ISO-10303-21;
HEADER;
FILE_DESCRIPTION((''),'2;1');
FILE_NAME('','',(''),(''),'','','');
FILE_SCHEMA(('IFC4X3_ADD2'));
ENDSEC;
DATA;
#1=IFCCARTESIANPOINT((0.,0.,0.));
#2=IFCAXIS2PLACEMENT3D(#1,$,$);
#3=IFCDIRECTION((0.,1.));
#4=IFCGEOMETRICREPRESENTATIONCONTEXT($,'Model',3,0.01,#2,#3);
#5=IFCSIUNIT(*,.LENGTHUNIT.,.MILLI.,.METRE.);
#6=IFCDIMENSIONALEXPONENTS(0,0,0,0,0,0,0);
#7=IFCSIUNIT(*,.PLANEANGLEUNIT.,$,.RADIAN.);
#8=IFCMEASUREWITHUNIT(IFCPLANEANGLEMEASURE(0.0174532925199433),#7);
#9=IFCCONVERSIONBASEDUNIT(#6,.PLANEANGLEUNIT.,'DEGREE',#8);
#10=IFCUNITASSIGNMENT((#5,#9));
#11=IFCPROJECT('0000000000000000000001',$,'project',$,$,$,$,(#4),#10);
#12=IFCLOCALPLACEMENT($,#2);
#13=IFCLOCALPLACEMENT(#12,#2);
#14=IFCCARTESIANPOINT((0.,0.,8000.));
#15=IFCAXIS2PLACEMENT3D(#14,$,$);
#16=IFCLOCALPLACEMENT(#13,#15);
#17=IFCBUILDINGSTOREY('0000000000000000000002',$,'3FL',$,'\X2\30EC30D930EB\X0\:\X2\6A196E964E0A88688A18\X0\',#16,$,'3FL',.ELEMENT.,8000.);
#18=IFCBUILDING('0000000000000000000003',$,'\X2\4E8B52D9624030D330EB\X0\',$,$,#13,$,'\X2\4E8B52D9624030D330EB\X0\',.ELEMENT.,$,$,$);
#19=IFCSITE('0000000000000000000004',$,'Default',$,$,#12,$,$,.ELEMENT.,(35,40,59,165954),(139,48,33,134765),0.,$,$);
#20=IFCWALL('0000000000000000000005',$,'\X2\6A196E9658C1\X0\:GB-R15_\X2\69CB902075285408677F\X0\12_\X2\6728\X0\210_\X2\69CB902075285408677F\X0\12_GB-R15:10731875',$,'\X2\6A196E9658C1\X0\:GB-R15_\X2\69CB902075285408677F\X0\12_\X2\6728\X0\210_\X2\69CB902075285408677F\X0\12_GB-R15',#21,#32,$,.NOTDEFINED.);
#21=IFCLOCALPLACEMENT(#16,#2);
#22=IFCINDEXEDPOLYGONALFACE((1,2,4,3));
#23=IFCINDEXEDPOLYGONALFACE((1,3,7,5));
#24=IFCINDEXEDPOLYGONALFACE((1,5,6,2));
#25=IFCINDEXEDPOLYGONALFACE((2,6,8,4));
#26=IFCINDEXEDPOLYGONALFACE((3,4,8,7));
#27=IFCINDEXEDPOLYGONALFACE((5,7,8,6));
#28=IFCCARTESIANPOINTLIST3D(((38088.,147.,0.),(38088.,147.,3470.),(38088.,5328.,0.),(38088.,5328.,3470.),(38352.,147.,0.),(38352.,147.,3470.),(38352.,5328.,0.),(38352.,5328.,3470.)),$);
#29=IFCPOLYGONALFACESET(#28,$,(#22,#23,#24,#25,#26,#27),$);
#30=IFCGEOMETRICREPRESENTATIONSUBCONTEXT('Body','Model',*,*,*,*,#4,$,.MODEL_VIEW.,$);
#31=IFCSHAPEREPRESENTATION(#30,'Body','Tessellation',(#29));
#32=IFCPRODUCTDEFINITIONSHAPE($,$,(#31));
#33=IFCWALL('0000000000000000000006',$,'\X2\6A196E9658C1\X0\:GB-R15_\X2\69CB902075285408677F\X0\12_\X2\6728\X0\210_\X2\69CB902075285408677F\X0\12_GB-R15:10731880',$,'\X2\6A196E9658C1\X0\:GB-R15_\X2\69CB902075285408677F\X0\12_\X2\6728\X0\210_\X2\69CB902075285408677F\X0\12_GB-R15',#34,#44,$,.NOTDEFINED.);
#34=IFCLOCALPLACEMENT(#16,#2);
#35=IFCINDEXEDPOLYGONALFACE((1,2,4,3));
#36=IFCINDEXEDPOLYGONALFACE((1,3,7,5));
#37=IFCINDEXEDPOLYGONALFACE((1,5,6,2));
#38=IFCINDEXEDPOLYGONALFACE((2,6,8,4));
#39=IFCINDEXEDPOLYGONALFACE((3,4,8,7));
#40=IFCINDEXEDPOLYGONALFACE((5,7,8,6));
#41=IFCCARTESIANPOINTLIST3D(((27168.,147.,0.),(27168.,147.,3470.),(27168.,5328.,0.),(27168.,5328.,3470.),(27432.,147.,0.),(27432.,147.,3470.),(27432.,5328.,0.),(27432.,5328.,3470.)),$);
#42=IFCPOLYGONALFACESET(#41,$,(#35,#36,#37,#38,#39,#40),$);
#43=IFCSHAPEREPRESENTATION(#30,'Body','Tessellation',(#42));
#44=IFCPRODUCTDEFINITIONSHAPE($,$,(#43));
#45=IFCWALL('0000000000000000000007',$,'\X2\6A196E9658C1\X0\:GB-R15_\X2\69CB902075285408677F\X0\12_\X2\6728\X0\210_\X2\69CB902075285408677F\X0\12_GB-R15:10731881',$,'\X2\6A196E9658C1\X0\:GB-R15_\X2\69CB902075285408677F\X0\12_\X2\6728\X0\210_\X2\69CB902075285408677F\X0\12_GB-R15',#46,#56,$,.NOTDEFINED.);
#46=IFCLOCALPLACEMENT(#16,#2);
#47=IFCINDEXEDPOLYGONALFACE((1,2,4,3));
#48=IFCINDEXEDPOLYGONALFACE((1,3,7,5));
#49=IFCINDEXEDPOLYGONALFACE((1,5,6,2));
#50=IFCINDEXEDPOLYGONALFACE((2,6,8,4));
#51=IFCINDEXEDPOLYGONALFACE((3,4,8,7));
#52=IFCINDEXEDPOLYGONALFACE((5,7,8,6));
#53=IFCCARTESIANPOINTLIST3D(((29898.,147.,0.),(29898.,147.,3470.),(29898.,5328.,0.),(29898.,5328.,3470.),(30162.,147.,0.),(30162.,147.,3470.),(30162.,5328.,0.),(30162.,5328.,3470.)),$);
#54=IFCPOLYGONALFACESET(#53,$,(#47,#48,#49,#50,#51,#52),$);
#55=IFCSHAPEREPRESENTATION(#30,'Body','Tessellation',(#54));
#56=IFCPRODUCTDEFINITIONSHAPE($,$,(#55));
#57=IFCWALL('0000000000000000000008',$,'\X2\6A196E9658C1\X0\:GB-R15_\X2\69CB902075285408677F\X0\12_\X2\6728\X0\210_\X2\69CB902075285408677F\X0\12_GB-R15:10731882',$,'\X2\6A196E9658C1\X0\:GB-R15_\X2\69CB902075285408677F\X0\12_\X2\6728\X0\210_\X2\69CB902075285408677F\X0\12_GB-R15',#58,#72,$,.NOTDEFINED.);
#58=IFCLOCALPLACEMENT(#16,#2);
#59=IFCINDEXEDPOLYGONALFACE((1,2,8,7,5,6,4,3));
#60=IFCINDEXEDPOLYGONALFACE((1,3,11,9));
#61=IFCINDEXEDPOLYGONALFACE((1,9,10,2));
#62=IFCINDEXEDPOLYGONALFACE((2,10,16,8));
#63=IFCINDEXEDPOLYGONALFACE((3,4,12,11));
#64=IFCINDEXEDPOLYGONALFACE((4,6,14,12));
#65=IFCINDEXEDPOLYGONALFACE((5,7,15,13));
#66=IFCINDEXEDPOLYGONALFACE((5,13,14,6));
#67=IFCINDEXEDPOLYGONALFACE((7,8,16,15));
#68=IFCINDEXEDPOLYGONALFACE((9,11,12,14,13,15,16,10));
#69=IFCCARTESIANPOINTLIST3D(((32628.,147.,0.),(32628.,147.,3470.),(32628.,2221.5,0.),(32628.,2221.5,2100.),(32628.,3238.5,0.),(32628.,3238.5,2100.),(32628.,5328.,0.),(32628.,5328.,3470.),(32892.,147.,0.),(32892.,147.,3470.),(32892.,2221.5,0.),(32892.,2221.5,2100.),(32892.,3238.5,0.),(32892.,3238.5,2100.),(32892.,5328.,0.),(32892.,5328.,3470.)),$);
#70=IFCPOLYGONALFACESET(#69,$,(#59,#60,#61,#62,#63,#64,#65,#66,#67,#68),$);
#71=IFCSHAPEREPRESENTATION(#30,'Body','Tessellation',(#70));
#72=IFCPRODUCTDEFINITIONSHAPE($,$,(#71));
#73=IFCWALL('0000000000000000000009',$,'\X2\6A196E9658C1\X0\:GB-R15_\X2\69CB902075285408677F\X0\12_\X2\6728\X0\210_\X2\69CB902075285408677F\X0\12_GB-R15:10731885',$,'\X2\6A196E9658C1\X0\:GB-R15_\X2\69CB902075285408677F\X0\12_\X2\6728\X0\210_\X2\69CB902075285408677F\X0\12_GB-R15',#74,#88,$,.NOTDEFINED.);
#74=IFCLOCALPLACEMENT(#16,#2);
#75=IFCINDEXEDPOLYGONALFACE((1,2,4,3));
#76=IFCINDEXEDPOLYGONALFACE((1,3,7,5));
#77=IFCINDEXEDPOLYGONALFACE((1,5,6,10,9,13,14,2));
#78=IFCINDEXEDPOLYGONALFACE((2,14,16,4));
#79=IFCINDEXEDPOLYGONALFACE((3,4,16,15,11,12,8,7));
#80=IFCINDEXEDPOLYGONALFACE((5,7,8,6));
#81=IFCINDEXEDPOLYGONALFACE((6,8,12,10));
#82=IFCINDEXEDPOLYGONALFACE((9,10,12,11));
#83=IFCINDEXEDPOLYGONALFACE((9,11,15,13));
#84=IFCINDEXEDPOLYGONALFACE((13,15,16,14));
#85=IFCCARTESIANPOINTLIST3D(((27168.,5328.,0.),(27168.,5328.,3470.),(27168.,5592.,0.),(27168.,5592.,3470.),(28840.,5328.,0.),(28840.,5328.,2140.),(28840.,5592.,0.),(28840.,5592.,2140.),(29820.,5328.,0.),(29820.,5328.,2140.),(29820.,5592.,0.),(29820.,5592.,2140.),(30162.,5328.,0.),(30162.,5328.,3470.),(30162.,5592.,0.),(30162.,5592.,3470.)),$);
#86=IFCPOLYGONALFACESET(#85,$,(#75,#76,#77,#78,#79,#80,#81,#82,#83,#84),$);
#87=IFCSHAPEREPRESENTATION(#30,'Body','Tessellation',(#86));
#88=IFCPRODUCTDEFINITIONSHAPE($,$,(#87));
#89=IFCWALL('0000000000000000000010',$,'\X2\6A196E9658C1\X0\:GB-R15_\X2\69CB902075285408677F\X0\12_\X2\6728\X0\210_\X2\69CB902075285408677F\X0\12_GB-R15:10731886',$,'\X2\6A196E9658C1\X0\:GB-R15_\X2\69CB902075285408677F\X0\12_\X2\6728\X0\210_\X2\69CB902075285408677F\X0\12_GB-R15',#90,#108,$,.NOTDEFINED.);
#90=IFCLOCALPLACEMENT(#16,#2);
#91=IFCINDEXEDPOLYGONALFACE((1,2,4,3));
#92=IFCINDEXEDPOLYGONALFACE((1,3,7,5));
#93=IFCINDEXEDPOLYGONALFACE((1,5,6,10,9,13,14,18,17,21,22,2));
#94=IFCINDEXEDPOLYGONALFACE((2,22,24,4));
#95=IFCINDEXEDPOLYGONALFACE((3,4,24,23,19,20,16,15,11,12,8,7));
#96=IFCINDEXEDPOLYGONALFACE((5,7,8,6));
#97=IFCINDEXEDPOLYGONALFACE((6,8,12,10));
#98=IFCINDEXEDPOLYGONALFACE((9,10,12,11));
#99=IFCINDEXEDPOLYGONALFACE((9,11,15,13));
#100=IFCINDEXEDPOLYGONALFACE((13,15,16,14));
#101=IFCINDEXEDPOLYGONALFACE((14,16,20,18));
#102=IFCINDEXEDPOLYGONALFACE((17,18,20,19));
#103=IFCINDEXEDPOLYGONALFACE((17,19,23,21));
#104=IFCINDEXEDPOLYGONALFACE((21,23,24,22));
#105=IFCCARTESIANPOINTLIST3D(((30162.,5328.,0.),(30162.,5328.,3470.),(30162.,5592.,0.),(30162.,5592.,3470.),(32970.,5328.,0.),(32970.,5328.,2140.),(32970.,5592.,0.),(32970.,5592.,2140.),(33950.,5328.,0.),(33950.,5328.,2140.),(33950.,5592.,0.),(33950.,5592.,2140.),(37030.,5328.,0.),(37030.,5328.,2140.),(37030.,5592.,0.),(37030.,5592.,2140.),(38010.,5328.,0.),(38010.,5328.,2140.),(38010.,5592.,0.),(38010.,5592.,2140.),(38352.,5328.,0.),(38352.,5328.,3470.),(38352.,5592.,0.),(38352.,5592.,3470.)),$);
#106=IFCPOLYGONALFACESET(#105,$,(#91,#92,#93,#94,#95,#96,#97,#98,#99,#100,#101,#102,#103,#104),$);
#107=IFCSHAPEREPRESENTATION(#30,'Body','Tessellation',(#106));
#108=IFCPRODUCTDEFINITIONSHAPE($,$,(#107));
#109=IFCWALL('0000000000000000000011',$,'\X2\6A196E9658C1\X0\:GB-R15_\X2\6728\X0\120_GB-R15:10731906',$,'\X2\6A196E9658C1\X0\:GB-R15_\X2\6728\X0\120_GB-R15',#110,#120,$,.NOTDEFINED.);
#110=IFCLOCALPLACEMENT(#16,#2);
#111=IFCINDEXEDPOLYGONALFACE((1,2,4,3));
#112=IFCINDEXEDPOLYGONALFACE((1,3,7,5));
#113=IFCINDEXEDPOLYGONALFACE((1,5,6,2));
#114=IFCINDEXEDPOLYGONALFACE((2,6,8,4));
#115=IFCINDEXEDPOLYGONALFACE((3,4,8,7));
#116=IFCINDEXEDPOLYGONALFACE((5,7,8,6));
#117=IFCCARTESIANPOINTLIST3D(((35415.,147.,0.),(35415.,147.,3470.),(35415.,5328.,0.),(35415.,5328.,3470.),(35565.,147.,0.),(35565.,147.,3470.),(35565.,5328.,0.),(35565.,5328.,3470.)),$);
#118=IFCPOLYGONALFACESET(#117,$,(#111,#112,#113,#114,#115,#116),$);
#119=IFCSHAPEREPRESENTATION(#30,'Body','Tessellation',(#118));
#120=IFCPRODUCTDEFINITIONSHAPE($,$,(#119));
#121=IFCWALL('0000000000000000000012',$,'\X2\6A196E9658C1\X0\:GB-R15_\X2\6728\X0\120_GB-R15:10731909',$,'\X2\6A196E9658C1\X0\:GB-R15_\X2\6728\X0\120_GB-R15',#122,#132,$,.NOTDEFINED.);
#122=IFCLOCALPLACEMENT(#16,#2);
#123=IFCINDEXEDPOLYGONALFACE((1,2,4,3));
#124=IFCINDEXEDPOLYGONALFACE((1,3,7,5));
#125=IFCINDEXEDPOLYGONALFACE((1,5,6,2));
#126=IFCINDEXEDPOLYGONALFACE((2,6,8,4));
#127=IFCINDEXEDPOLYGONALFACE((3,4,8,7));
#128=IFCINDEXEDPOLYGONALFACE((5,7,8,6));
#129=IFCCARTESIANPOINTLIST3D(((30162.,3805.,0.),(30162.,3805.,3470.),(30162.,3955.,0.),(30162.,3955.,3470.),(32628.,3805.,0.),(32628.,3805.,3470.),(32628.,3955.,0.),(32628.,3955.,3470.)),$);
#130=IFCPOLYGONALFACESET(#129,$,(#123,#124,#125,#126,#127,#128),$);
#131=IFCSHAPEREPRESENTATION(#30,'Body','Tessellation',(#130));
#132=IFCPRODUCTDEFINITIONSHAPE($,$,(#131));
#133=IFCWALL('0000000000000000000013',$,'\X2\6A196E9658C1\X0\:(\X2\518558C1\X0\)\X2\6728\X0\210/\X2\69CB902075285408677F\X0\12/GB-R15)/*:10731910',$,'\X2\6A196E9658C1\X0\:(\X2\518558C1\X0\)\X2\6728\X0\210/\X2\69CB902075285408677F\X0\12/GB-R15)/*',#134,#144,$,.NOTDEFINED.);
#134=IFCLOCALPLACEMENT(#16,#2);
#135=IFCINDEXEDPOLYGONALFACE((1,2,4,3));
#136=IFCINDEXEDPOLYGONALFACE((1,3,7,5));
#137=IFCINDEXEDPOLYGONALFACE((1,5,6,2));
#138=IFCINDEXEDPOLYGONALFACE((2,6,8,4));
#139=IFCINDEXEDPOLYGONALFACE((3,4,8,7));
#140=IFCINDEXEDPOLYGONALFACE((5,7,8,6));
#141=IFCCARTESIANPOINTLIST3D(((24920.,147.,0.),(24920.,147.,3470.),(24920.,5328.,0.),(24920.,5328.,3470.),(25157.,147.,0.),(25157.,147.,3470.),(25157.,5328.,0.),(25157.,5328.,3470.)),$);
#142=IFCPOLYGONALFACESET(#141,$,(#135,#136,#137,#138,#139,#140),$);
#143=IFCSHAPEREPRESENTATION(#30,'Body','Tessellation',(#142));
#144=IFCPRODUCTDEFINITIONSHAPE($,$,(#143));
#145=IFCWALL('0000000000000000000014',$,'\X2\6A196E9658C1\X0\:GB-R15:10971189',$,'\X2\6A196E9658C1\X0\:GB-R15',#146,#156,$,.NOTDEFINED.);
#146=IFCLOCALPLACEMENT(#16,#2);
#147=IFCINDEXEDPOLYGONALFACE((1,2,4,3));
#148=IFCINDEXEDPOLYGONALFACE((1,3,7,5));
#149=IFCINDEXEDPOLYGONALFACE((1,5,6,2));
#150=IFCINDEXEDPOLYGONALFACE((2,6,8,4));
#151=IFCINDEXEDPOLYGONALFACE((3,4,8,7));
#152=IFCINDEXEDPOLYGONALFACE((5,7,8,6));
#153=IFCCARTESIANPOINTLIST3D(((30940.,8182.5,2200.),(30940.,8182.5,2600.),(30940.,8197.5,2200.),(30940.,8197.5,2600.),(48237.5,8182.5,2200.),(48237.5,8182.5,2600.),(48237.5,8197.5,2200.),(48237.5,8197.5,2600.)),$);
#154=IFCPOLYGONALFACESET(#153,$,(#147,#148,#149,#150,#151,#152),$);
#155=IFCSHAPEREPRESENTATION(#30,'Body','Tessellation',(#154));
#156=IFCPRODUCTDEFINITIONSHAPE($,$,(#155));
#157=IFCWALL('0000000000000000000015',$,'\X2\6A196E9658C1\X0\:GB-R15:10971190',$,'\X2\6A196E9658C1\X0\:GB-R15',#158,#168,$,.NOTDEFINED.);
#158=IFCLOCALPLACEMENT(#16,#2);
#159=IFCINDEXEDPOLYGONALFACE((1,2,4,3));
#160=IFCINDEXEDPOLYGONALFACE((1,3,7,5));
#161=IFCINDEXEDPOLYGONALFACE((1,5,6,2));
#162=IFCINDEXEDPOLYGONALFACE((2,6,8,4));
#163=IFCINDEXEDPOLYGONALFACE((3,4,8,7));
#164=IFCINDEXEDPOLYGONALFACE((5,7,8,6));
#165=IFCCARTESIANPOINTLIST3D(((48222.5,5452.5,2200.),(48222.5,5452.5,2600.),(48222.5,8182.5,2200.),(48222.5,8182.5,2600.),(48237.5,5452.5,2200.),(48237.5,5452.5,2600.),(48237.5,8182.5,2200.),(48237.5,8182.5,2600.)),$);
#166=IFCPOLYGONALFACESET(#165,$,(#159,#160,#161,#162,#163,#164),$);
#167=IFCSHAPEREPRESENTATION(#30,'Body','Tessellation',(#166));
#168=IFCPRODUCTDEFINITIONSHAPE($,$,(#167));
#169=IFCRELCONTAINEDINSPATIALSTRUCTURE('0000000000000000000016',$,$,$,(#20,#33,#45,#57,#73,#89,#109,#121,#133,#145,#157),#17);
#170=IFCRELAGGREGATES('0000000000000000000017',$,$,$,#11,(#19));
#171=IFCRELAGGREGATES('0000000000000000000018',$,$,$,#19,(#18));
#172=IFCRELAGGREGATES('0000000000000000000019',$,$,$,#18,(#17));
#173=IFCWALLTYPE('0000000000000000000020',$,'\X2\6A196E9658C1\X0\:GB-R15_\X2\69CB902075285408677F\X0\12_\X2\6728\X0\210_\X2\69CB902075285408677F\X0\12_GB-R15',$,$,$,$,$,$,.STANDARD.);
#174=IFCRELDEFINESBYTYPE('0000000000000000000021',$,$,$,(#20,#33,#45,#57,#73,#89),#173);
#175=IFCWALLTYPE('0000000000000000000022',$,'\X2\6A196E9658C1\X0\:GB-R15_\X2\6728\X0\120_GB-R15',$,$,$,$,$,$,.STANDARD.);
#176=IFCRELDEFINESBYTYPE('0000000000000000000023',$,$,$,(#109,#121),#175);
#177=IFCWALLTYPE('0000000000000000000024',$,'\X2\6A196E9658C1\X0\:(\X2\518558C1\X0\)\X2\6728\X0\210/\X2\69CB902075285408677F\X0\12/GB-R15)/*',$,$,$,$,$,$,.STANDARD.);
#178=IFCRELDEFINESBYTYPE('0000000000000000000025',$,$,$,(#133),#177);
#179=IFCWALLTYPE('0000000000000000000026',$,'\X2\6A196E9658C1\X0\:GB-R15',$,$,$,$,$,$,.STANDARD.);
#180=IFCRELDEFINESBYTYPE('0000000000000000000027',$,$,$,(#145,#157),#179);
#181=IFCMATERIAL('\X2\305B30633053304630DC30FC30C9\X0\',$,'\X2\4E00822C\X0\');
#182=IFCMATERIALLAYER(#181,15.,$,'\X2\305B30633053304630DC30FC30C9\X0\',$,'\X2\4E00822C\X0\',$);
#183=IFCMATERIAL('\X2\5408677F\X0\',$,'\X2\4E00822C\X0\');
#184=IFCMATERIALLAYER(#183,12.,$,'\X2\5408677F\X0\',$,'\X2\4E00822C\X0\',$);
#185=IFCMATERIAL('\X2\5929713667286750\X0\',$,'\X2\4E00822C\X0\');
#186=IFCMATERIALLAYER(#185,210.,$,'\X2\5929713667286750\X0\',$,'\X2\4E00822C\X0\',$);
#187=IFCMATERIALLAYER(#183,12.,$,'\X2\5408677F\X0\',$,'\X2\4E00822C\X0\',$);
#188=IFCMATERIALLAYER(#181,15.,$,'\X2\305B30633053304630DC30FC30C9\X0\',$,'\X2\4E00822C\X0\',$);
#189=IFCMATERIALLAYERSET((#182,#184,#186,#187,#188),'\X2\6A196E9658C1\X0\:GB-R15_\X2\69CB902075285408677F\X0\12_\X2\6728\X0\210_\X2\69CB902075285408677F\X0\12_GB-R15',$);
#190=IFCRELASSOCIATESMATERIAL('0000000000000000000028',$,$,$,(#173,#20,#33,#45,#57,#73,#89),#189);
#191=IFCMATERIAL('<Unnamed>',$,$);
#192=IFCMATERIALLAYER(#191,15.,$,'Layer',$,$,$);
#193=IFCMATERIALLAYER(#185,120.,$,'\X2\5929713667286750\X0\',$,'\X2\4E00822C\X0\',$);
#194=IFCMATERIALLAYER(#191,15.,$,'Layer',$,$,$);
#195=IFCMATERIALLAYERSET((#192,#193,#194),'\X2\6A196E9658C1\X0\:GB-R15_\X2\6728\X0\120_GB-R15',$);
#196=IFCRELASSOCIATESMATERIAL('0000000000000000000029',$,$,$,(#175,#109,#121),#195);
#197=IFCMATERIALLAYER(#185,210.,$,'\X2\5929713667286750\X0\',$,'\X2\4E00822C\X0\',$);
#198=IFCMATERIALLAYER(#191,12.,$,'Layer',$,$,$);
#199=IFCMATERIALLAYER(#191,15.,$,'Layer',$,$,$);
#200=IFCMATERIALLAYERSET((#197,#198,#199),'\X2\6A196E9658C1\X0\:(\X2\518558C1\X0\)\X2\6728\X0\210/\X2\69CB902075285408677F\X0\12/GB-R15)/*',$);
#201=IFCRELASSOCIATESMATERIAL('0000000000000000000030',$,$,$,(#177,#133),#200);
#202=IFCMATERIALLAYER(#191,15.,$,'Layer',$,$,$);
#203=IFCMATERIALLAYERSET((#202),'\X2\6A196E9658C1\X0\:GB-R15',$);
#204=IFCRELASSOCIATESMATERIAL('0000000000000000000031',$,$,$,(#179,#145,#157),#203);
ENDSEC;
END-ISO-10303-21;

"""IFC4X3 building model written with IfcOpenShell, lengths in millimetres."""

from ifc_helpers import new_model, entity, si_unit, converted_unit, direction, frame, frame_2d, origin, place, context, subcontext, project, spatial, rectangle, extrude, material, layer, layer_set, type_object, element, save


model = new_model("IFC4X3")

# Units and contexts
model_context = context("Model", 3, precision=0.01, world=origin(), true_north=direction((0.0, 1.0)))
body_context = subcontext(model_context, "Body", "Model", "MODEL_VIEW")
ifc_project = project(units=[si_unit("LENGTHUNIT", "METRE", prefix="MILLI"), converted_unit("PLANEANGLEUNIT", "DEGREE", entity("IfcPlaneAngleMeasure", 0.0174532925199433), si_unit("PLANEANGLEUNIT", "RADIAN"), dimensions=[0, 0, 0, 0, 0, 0, 0])], contexts=[model_context])

# Site, building, storey
site_placement = place(None, origin())
site = spatial("IfcSite", under=ifc_project, at=site_placement, Name="Default", CompositionType="ELEMENT", RefLatitude=(35, 40, 59, 165954), RefLongitude=(139, 48, 33, 134765), RefElevation=0.0)
building_placement = place(site_placement, origin())
building = spatial("IfcBuilding", under=site, at=building_placement, Name="事務所ビル", LongName="事務所ビル", CompositionType="ELEMENT")
storey_placement = place(building_placement, frame((0.0, 0.0, 8000.0)))
storey = spatial("IfcBuildingStorey", under=building, at=storey_placement, Name="3FL", ObjectType="レベル:標準上表記", LongName="3FL", CompositionType="ELEMENT", Elevation=8000.0)

# Walls
ifc_material_1 = material(Name="せっこうボード", Category="一般")
ifc_layer_1 = layer(ifc_material_1, 15.0, Name="せっこうボード", Category="一般")
ifc_material_2 = material(Name="合板", Category="一般")
ifc_layer_2 = layer(ifc_material_2, 12.0, Name="合板", Category="一般")
ifc_material_3 = material(Name="天然木材", Category="一般")
ifc_layer_3 = layer(ifc_material_3, 210.0, Name="天然木材", Category="一般")
ifc_layer_4 = layer(ifc_material_2, 12.0, Name="合板", Category="一般")
ifc_layer_5 = layer(ifc_material_1, 15.0, Name="せっこうボード", Category="一般")
ifc_layer_set_1 = layer_set([ifc_layer_1, ifc_layer_2, ifc_layer_3, ifc_layer_4, ifc_layer_5], Name="標準壁:GB-R15_構造用合板12_木210_構造用合板12_GB-R15")
wall_type_1 = type_object("IfcWallType", Name="標準壁:GB-R15_構造用合板12_木210_構造用合板12_GB-R15", PredefinedType="STANDARD", material=ifc_layer_set_1)
wall_1_placement = place(storey_placement, frame((38220.0, 147.0, 0.0), z_axis=(0.0, 0.0, 1.0), x_axis=(0.0, 1.0, 0.0)))
element("IfcWall", 1, at=wall_1_placement, inside=storey, type_object=wall_type_1, material=ifc_layer_set_1, Name="標準壁:GB-R15_構造用合板12_木210_構造用合板12_GB-R15:10731875", ObjectType="標準壁:GB-R15_構造用合板12_木210_構造用合板12_GB-R15", PredefinedType="NOTDEFINED", context=body_context, shape_type="SweptSolid", body=[
    extrude(rectangle(XDim=5181.0, YDim=264.0, at=frame_2d((2590.5, 0.0), x_axis=(-1.0, 0.0))), origin(), (0.0, 0.0, 1.0), 3470.0),
])
wall_2_placement = place(storey_placement, frame((27300.0, 147.0, 0.0), z_axis=(0.0, 0.0, 1.0), x_axis=(0.0, 1.0, 0.0)))
element("IfcWall", 2, at=wall_2_placement, inside=storey, type_object=wall_type_1, material=ifc_layer_set_1, Name="標準壁:GB-R15_構造用合板12_木210_構造用合板12_GB-R15:10731880", ObjectType="標準壁:GB-R15_構造用合板12_木210_構造用合板12_GB-R15", PredefinedType="NOTDEFINED", context=body_context, shape_type="SweptSolid", body=[
    extrude(rectangle(XDim=5181.0, YDim=264.0, at=frame_2d((2590.5, 0.0), x_axis=(-1.0, 0.0))), origin(), (0.0, 0.0, 1.0), 3470.0),
])
wall_3_placement = place(storey_placement, frame((30030.0, 147.0, 0.0), z_axis=(0.0, 0.0, 1.0), x_axis=(0.0, 1.0, 0.0)))
element("IfcWall", 3, at=wall_3_placement, inside=storey, type_object=wall_type_1, material=ifc_layer_set_1, Name="標準壁:GB-R15_構造用合板12_木210_構造用合板12_GB-R15:10731881", ObjectType="標準壁:GB-R15_構造用合板12_木210_構造用合板12_GB-R15", PredefinedType="NOTDEFINED", context=body_context, shape_type="SweptSolid", body=[
    extrude(rectangle(XDim=5181.0, YDim=264.0, at=frame_2d((2590.5, 0.0), x_axis=(-1.0, 0.0))), origin(), (0.0, 0.0, 1.0), 3470.0),
])

# Walls, openings
wall_4_placement = place(storey_placement, frame((32760.0, 147.0, 0.0), z_axis=(0.0, 0.0, 1.0), x_axis=(0.0, 1.0, 0.0)))
wall_4 = element("IfcWall", 4, at=wall_4_placement, inside=storey, type_object=wall_type_1, material=ifc_layer_set_1, Name="標準壁:GB-R15_構造用合板12_木210_構造用合板12_GB-R15:10731882", ObjectType="標準壁:GB-R15_構造用合板12_木210_構造用合板12_GB-R15", PredefinedType="NOTDEFINED", context=body_context, shape_type="SweptSolid", body=[
    extrude(rectangle(XDim=5181.0, YDim=264.0, at=frame_2d((2590.5, 0.0), x_axis=(1.0, 0.0))), origin(), (0.0, 0.0, 1.0), 3470.0),
])
opening_1_placement = place(wall_4_placement, frame((2074.5, -132.0, 0.0)))
element("IfcOpeningElement", 5, at=opening_1_placement, cuts=wall_4, PredefinedType="OPENING", context=body_context, shape_type="SweptSolid", body=[
    extrude(rectangle(XDim=2100.0, YDim=1017.0, at=frame_2d((1050.0, 508.5), x_axis=(-1.0, 0.0))), frame((0.0, 0.0, 0.0), z_axis=(0.0, 1.0, 0.0), x_axis=(0.0, 0.0, 1.0)), (0.0, 0.0, 1.0), 264.0),
])
wall_5_placement = place(storey_placement, frame((27168.0, 5460.0, 0.0)))
wall_5 = element("IfcWall", 6, at=wall_5_placement, inside=storey, type_object=wall_type_1, material=ifc_layer_set_1, Name="標準壁:GB-R15_構造用合板12_木210_構造用合板12_GB-R15:10731885", ObjectType="標準壁:GB-R15_構造用合板12_木210_構造用合板12_GB-R15", PredefinedType="NOTDEFINED", context=body_context, shape_type="SweptSolid", body=[
    extrude(rectangle(XDim=2994.0, YDim=264.0, at=frame_2d((1497.0, 0.0), x_axis=(-1.0, 0.0))), origin(), (0.0, 0.0, 1.0), 3470.0),
])
opening_2_placement = place(wall_5_placement, frame((1672.0, -132.0, 0.0)))
element("IfcOpeningElement", 7, at=opening_2_placement, cuts=wall_5, PredefinedType="OPENING", context=body_context, shape_type="SweptSolid", body=[
    extrude(rectangle(XDim=2140.0, YDim=980.0, at=frame_2d((1070.0, 490.0), x_axis=(-1.0, 0.0))), frame((0.0, 0.0, 0.0), z_axis=(0.0, 1.0, 0.0), x_axis=(0.0, 0.0, 1.0)), (0.0, 0.0, 1.0), 264.0),
])

# Wall, openings
wall_6_placement = place(storey_placement, frame((30162.0, 5460.0, 0.0)))
wall_6 = element("IfcWall", 8, at=wall_6_placement, inside=storey, type_object=wall_type_1, material=ifc_layer_set_1, Name="標準壁:GB-R15_構造用合板12_木210_構造用合板12_GB-R15:10731886", ObjectType="標準壁:GB-R15_構造用合板12_木210_構造用合板12_GB-R15", PredefinedType="NOTDEFINED", context=body_context, shape_type="SweptSolid", body=[
    extrude(rectangle(XDim=8190.0, YDim=264.0, at=frame_2d((4095.0, 0.0), x_axis=(-1.0, 0.0))), origin(), (0.0, 0.0, 1.0), 3470.0),
])
opening_3_placement = place(wall_6_placement, frame((3788.0, 132.0, 0.0)))
element("IfcOpeningElement", 9, at=opening_3_placement, cuts=wall_6, PredefinedType="OPENING", context=body_context, shape_type="SweptSolid", body=[
    extrude(rectangle(XDim=2140.0, YDim=980.0, at=frame_2d((1070.0, 490.0), x_axis=(-1.0, 0.0))), frame((0.0, 0.0, 0.0), z_axis=(0.0, -1.0, 0.0), x_axis=(0.0, 0.0, 1.0)), (0.0, 0.0, 1.0), 264.0),
])
opening_4_placement = place(wall_6_placement, frame((7848.0, 132.0, 0.0)))
element("IfcOpeningElement", 10, at=opening_4_placement, cuts=wall_6, PredefinedType="OPENING", context=body_context, shape_type="SweptSolid", body=[
    extrude(rectangle(XDim=2140.0, YDim=980.0, at=frame_2d((1070.0, 490.0), x_axis=(-1.0, 0.0))), frame((0.0, 0.0, 0.0), z_axis=(0.0, -1.0, 0.0), x_axis=(0.0, 0.0, 1.0)), (0.0, 0.0, 1.0), 264.0),
])

# Walls
ifc_material_4 = material(Name="<Unnamed>")
ifc_layer_6 = layer(ifc_material_4, 15.0, Name="Layer")
ifc_layer_7 = layer(ifc_material_3, 120.0, Name="天然木材", Category="一般")
ifc_layer_8 = layer(ifc_material_4, 15.0, Name="Layer")
ifc_layer_set_2 = layer_set([ifc_layer_6, ifc_layer_7, ifc_layer_8], Name="標準壁:GB-R15_木120_GB-R15")
wall_type_2 = type_object("IfcWallType", Name="標準壁:GB-R15_木120_GB-R15", PredefinedType="STANDARD", material=ifc_layer_set_2)
wall_7_placement = place(storey_placement, frame((35490.0, 147.0, 0.0), z_axis=(0.0, 0.0, 1.0), x_axis=(0.0, 1.0, 0.0)))
element("IfcWall", 11, at=wall_7_placement, inside=storey, type_object=wall_type_2, material=ifc_layer_set_2, Name="標準壁:GB-R15_木120_GB-R15:10731906", ObjectType="標準壁:GB-R15_木120_GB-R15", PredefinedType="NOTDEFINED", context=body_context, shape_type="SweptSolid", body=[
    extrude(rectangle(XDim=5181.0, YDim=150.0, at=frame_2d((2590.5, 0.0), x_axis=(-1.0, 0.0))), origin(), (0.0, 0.0, 1.0), 3470.0),
])
wall_8_placement = place(storey_placement, frame((32628.0, 3880.0, 0.0), z_axis=(0.0, 0.0, 1.0), x_axis=(-1.0, 0.0, 0.0)))
element("IfcWall", 12, at=wall_8_placement, inside=storey, type_object=wall_type_2, material=ifc_layer_set_2, Name="標準壁:GB-R15_木120_GB-R15:10731909", ObjectType="標準壁:GB-R15_木120_GB-R15", PredefinedType="NOTDEFINED", context=body_context, shape_type="SweptSolid", body=[
    extrude(rectangle(XDim=2466.0, YDim=150.0, at=frame_2d((1233.0, 0.0), x_axis=(-1.0, 0.0))), origin(), (0.0, 0.0, 1.0), 3470.0),
])
ifc_layer_9 = layer(ifc_material_3, 210.0, Name="天然木材", Category="一般")
ifc_layer_10 = layer(ifc_material_4, 12.0, Name="Layer")
ifc_layer_11 = layer(ifc_material_4, 15.0, Name="Layer")
ifc_layer_set_3 = layer_set([ifc_layer_9, ifc_layer_10, ifc_layer_11], Name="標準壁:(内壁)木210/構造用合板12/GB-R15)/*")
wall_type_3 = type_object("IfcWallType", Name="標準壁:(内壁)木210/構造用合板12/GB-R15)/*", PredefinedType="STANDARD", material=ifc_layer_set_3)
wall_9_placement = place(storey_placement, frame((25038.5, 147.0, 0.0), z_axis=(0.0, 0.0, 1.0), x_axis=(0.0, 1.0, 0.0)))
element("IfcWall", 13, at=wall_9_placement, inside=storey, type_object=wall_type_3, material=ifc_layer_set_3, Name="標準壁:(内壁)木210/構造用合板12/GB-R15)/*:10731910", ObjectType="標準壁:(内壁)木210/構造用合板12/GB-R15)/*", PredefinedType="NOTDEFINED", context=body_context, shape_type="SweptSolid", body=[
    extrude(rectangle(XDim=5181.0, YDim=237.0, at=frame_2d((2590.5, 0.0), x_axis=(-1.0, 0.0))), origin(), (0.0, 0.0, 1.0), 3470.0),
])
ifc_layer_12 = layer(ifc_material_4, 15.0, Name="Layer")
ifc_layer_set_4 = layer_set([ifc_layer_12], Name="標準壁:GB-R15")
wall_type_4 = type_object("IfcWallType", Name="標準壁:GB-R15", PredefinedType="STANDARD", material=ifc_layer_set_4)
wall_10_placement = place(storey_placement, frame((30940.0, 8190.0, 2200.0)))
element("IfcWall", 14, at=wall_10_placement, inside=storey, type_object=wall_type_4, material=ifc_layer_set_4, Name="標準壁:GB-R15:10971189", ObjectType="標準壁:GB-R15", PredefinedType="NOTDEFINED", context=body_context, shape_type="SweptSolid", body=[
    extrude(rectangle(XDim=17297.5, YDim=15.0, at=frame_2d((8648.8, 0.0), x_axis=(-1.0, 0.0))), origin(), (0.0, 0.0, 1.0), 400.0),
])
wall_11_placement = place(storey_placement, frame((48230.0, 8182.5, 2200.0), z_axis=(0.0, 0.0, 1.0), x_axis=(0.0, -1.0, 0.0)))
element("IfcWall", 15, at=wall_11_placement, inside=storey, type_object=wall_type_4, material=ifc_layer_set_4, Name="標準壁:GB-R15:10971190", ObjectType="標準壁:GB-R15", PredefinedType="NOTDEFINED", context=body_context, shape_type="SweptSolid", body=[
    extrude(rectangle(XDim=2730.0, YDim=15.0, at=frame_2d((1365.0, 0.0), x_axis=(-1.0, 0.0))), origin(), (0.0, 0.0, 1.0), 400.0),
])

save(model, "model.ifc")
